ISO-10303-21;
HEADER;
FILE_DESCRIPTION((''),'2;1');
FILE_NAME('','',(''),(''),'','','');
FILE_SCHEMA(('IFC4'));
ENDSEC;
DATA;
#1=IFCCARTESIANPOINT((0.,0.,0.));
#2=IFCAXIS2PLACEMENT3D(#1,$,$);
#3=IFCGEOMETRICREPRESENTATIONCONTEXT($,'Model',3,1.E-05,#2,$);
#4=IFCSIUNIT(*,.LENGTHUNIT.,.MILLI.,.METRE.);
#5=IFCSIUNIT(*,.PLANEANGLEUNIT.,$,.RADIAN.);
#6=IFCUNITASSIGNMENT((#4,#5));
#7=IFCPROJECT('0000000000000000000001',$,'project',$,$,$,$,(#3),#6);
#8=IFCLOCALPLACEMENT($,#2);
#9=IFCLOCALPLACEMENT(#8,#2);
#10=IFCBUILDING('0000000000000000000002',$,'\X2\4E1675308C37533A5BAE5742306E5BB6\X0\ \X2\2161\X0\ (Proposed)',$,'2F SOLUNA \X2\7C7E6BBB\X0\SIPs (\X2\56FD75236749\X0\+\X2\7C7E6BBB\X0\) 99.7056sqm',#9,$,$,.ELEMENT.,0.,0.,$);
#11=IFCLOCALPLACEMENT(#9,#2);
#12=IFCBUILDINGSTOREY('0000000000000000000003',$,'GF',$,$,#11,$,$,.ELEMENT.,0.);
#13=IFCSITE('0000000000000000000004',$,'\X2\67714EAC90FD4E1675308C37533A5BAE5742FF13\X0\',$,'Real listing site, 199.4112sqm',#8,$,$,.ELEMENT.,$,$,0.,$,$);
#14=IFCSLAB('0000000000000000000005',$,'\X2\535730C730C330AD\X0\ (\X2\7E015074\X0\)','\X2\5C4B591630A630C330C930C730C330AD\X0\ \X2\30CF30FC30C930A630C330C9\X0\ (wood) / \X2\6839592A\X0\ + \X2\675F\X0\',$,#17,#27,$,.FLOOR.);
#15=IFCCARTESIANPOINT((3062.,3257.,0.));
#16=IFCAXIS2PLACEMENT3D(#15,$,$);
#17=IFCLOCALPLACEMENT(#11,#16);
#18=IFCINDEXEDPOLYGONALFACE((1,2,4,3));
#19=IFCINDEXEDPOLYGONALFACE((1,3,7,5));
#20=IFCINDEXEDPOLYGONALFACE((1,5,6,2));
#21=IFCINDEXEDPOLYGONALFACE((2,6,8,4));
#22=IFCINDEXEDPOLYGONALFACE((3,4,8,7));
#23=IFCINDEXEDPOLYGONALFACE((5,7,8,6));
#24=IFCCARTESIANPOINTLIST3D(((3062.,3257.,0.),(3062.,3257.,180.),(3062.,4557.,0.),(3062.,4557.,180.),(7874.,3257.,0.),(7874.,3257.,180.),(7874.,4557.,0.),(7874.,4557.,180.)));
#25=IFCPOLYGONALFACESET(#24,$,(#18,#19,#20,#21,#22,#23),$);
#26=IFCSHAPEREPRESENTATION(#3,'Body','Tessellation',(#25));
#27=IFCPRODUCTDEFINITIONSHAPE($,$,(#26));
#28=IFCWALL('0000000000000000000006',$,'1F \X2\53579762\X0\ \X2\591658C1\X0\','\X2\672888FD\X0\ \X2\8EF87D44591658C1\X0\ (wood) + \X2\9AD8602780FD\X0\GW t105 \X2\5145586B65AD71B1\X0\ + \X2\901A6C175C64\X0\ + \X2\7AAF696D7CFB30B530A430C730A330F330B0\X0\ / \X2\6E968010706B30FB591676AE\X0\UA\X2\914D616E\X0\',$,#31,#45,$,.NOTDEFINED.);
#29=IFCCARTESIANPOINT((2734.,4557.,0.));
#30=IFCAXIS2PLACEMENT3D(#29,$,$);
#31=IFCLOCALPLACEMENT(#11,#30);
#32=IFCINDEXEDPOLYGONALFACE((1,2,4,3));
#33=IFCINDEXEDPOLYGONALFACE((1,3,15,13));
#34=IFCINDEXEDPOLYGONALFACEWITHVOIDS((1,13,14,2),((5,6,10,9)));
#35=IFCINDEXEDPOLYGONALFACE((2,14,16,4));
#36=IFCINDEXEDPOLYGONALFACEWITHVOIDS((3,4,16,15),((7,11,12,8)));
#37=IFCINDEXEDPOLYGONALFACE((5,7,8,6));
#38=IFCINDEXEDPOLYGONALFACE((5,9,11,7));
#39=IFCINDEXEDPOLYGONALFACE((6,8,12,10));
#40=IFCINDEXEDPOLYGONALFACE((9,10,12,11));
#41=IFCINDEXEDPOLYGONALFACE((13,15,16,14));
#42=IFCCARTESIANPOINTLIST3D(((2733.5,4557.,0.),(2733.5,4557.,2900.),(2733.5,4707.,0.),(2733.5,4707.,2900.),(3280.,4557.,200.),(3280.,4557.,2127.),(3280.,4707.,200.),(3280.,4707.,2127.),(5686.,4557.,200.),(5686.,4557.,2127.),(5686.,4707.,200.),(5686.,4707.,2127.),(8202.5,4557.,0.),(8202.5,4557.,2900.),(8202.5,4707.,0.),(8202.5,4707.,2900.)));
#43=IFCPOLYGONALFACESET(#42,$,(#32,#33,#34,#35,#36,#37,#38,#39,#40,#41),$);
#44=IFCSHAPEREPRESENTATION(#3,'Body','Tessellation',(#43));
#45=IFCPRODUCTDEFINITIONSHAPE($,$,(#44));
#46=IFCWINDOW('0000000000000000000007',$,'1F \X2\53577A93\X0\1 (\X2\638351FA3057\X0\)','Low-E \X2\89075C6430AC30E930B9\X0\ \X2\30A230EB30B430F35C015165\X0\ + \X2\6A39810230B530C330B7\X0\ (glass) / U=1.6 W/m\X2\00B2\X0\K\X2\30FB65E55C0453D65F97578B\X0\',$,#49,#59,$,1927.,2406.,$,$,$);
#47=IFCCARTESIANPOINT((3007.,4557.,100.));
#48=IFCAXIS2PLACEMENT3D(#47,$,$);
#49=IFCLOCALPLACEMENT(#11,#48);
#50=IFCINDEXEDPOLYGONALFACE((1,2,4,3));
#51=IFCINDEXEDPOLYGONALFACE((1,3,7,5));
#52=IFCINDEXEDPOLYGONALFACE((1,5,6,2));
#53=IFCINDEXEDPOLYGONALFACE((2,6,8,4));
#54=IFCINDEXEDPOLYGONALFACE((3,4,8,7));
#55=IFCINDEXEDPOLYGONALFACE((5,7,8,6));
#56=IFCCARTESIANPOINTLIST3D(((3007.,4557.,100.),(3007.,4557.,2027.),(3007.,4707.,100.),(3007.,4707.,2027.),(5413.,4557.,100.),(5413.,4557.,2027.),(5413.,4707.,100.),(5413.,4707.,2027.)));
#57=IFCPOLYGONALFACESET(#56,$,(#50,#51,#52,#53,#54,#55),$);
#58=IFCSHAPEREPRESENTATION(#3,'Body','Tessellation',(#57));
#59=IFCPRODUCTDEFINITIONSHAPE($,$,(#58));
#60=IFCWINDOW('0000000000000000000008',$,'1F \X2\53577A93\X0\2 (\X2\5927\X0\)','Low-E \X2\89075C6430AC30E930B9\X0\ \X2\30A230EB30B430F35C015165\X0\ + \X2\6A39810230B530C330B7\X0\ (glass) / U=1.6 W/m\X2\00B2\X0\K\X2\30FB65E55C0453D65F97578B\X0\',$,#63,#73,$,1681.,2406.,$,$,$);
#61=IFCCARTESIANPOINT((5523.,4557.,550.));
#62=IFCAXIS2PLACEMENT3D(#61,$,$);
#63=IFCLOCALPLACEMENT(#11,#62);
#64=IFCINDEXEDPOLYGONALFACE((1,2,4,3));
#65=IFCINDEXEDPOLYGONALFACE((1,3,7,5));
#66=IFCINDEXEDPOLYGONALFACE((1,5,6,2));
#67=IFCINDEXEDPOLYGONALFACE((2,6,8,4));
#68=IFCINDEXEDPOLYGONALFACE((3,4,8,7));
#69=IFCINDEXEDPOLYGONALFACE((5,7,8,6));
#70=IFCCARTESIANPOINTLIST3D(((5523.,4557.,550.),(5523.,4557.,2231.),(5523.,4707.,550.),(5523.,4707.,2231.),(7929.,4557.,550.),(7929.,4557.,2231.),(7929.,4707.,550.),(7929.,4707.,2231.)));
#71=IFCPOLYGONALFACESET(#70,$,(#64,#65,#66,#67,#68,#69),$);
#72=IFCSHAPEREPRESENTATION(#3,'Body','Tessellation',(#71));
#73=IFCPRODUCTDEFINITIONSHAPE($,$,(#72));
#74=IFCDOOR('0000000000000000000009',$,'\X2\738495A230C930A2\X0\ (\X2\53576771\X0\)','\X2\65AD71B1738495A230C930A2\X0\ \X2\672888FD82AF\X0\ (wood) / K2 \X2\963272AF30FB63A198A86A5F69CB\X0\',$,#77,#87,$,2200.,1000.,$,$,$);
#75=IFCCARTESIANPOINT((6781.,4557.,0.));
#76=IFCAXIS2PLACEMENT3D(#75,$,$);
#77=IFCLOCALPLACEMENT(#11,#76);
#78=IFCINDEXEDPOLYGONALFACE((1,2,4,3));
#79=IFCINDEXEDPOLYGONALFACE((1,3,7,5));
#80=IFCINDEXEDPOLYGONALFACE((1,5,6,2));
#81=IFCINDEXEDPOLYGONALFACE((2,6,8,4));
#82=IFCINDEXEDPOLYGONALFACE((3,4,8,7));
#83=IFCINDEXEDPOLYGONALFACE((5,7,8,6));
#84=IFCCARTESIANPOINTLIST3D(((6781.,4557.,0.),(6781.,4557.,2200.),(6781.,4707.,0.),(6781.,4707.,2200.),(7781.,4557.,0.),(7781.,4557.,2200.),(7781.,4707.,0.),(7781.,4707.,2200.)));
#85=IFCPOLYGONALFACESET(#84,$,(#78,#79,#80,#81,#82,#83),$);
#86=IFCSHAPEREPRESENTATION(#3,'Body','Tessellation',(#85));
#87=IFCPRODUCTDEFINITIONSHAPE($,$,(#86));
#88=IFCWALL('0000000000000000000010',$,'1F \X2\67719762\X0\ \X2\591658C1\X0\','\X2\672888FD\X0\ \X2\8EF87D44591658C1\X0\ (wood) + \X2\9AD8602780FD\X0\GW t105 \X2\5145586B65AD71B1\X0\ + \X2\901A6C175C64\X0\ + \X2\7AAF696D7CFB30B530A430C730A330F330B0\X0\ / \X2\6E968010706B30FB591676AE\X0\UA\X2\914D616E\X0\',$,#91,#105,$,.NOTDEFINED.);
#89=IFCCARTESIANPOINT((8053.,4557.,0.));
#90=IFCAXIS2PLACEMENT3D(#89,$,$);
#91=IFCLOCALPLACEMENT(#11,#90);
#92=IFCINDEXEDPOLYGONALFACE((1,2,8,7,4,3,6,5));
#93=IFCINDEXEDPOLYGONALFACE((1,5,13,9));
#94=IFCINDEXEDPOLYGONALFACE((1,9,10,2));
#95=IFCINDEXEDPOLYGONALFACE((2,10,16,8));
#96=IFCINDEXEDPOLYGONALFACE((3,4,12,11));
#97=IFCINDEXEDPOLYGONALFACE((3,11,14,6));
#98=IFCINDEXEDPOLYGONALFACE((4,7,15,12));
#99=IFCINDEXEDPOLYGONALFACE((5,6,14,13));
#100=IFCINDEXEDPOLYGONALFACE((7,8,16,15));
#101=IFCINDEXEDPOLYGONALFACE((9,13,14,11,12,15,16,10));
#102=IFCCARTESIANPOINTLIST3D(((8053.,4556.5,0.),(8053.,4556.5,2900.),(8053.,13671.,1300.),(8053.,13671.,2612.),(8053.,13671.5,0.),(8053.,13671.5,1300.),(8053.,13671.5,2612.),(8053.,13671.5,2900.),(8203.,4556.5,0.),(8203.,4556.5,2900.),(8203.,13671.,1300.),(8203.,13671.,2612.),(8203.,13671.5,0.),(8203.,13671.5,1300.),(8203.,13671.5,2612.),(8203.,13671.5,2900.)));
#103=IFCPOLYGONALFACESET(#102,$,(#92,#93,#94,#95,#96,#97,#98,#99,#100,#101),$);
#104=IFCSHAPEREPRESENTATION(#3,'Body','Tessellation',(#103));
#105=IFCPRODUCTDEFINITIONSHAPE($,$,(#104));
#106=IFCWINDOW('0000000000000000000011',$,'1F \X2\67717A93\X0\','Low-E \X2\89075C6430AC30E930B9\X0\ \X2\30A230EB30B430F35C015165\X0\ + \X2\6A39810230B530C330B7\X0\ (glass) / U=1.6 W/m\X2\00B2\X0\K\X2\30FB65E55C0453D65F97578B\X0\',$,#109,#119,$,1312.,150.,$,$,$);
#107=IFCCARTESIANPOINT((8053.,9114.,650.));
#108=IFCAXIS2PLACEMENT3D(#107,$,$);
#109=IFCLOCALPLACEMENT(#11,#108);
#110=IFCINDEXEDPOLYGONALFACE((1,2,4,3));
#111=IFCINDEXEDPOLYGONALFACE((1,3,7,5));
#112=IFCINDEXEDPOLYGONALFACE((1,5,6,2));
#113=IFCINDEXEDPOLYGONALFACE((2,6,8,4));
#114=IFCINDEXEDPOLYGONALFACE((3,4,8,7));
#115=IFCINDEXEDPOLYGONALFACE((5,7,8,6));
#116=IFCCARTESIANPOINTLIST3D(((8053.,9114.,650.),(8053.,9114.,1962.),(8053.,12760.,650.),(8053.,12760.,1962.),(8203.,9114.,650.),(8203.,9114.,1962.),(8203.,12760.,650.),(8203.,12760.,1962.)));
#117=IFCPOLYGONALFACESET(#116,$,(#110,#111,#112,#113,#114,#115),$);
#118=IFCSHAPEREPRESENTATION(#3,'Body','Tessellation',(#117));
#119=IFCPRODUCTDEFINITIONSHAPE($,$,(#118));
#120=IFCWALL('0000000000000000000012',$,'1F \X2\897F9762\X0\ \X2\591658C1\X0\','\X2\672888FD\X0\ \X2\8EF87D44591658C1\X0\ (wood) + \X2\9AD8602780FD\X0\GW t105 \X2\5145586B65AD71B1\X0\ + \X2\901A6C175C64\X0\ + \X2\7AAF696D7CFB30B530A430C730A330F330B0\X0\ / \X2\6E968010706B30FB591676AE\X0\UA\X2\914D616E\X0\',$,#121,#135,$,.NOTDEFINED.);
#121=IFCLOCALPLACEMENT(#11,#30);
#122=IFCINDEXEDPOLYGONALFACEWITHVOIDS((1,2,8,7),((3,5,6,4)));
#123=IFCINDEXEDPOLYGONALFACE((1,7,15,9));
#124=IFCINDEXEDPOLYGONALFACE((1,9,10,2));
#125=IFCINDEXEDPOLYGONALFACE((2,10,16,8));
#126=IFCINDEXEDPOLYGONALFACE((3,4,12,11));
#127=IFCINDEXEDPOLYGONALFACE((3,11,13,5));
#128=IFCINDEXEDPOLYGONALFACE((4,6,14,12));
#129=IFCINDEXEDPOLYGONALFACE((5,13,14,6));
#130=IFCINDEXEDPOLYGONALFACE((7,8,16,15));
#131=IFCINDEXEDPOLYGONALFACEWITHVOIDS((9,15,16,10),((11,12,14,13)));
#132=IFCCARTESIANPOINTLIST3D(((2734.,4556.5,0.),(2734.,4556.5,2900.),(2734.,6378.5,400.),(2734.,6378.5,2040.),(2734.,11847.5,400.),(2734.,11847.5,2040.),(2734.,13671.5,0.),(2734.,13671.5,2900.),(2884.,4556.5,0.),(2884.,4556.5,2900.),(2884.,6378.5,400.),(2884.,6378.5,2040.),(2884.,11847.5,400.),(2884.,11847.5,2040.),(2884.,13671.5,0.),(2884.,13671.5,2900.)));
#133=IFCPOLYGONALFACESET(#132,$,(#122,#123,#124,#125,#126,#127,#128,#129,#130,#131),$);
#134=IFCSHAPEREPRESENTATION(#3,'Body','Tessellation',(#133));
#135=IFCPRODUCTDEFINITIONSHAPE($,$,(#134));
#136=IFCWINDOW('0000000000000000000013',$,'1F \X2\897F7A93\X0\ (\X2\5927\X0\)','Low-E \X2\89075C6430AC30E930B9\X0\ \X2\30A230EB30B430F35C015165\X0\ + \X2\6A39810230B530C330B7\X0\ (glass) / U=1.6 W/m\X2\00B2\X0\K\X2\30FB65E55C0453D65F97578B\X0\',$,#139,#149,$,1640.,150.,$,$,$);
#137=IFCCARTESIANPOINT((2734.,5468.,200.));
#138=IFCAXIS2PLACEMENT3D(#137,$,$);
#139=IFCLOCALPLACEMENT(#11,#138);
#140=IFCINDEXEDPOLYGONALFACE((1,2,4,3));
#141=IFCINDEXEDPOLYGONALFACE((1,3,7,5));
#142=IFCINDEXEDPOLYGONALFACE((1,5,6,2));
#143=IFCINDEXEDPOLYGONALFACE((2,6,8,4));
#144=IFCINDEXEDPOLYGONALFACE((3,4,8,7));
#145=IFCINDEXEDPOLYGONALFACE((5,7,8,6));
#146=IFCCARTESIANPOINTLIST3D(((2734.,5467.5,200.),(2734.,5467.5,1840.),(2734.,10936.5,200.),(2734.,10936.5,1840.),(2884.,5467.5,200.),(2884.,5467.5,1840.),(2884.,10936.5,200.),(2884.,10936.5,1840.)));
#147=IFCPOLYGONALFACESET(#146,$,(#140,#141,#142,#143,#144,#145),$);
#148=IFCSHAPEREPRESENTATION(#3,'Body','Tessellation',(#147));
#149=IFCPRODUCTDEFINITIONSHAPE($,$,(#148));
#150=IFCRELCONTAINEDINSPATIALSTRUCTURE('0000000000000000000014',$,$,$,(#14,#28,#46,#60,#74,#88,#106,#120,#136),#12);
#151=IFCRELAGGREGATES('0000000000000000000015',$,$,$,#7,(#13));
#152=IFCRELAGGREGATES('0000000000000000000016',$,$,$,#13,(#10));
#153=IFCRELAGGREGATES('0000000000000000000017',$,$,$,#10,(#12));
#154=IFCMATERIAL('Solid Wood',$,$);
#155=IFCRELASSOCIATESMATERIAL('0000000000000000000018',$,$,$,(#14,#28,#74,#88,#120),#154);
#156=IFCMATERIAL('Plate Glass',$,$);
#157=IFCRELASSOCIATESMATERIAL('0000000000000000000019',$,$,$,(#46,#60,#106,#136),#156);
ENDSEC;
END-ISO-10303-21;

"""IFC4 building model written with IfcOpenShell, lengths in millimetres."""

from ifc_helpers import new_model, si_unit, frame, frame_2d, origin, place, context, project, spatial, rectangle, extrude, material, element, fill, save


model = new_model("IFC4")

# Units and contexts
model_context = context("Model", 3, precision=1e-05, world=origin())
ifc_project = project(units=[si_unit("LENGTHUNIT", "METRE", prefix="MILLI"), si_unit("PLANEANGLEUNIT", "RADIAN")], contexts=[model_context])

# Site, building, storey
site_placement = place(None, origin())
site = spatial("IfcSite", under=ifc_project, at=site_placement, Name="東京都世田谷区宮坂３", ObjectType="Real listing site, 199.4112sqm", CompositionType="ELEMENT", RefElevation=0.0)
building_placement = place(site_placement, origin())
building = spatial("IfcBuilding", under=site, at=building_placement, Name="世田谷区宮坂の家 Ⅱ (Proposed)", ObjectType="2F SOLUNA 籾殻SIPs (国産杉+籾殻) 99.7056sqm", CompositionType="ELEMENT", ElevationOfRefHeight=0.0, ElevationOfTerrain=0.0)
storey_placement = place(building_placement, origin())
storey = spatial("IfcBuildingStorey", under=building, at=storey_placement, Name="GF", CompositionType="ELEMENT", Elevation=0.0)

# Slab
ifc_material_1 = material(Name="Solid Wood")
slab_1_placement = place(storey_placement, frame((3062.0, 3257.0, 0.0)))
element("IfcSlab", 1, at=slab_1_placement, inside=storey, material=ifc_material_1, Name="南デッキ (縁側)", Description="屋外ウッドデッキ ハードウッド (wood) / 根太 + 束", PredefinedType="FLOOR", context=model_context, shape_type="SweptSolid", body=[
    extrude(rectangle(XDim=4812.0, YDim=1300.0, at=frame_2d((2406.0, 650.0))), frame((3062.0, 3257.0, 0.0)), (0.0, 0.0, 1.0), 180.0),
])

# Wall, openings, windows, door
wall_1_placement = place(storey_placement, frame((2734.0, 4557.0, 0.0)))
wall_1 = element("IfcWall", 2, at=wall_1_placement, inside=storey, material=ifc_material_1, Name="1F 南面 外壁", Description="木製 軸組外壁 (wood) + 高性能GW t105 充填断熱 + 通気層 + 窯業系サイディング / 準耐火・外皮UA配慮", PredefinedType="NOTDEFINED", context=model_context, shape_type="SweptSolid", body=[
    extrude(rectangle(XDim=5469.0, YDim=150.0, at=frame_2d((2734.0, 75.0))), frame((2734.0, 4557.0, 0.0)), (0.0, 0.0, 1.0), 2900.0),
])
opening_1_placement = place(storey_placement, frame((3007.0, 4557.0, 100.0)))
opening_1 = element("IfcOpeningElement", 3, at=opening_1_placement, cuts=wall_1, PredefinedType="NOTDEFINED", context=model_context, shape_type="SweptSolid", body=[
    extrude(rectangle(XDim=2406.0, YDim=150.0, at=frame_2d((1203.0, 75.0))), frame((3007.0, 4557.0, 100.0)), (0.0, 0.0, 1.0), 1927.0),
])
opening_2_placement = place(storey_placement, frame((5523.0, 4557.0, 550.0)))
opening_2 = element("IfcOpeningElement", 4, at=opening_2_placement, cuts=wall_1, PredefinedType="NOTDEFINED", context=model_context, shape_type="SweptSolid", body=[
    extrude(rectangle(XDim=2406.0, YDim=150.0, at=frame_2d((1203.0, 75.0))), frame((5523.0, 4557.0, 550.0)), (0.0, 0.0, 1.0), 1681.0),
])
opening_3_placement = place(storey_placement, frame((6781.0, 4557.0, 0.0)))
opening_3 = element("IfcOpeningElement", 5, at=opening_3_placement, cuts=wall_1, PredefinedType="NOTDEFINED", context=model_context, shape_type="SweptSolid", body=[
    extrude(rectangle(XDim=1000.0, YDim=150.0, at=frame_2d((500.0, 75.0))), frame((6781.0, 4557.0, 0.0)), (0.0, 0.0, 1.0), 2200.0),
])
ifc_material_2 = material(Name="Plate Glass")
window_1_placement = place(storey_placement, frame((3007.0, 4557.0, 100.0)))
window_1 = element("IfcWindow", 6, at=window_1_placement, inside=storey, material=ifc_material_2, Name="1F 南窓1 (掃出し)", Description="Low-E 複層ガラス アルゴン封入 + 樹脂サッシ (glass) / U=1.6 W/m²K・日射取得型", OverallHeight=1927.0, OverallWidth=2406.0, context=model_context, shape_type="SweptSolid", body=[
    extrude(rectangle(XDim=2406.0, YDim=150.0, at=frame_2d((1203.0, 75.0))), frame((3007.0, 4557.0, 100.0)), (0.0, 0.0, 1.0), 1927.0),
])
fill(opening_1, window_1)
window_2_placement = place(storey_placement, frame((5523.0, 4557.0, 550.0)))
window_2 = element("IfcWindow", 7, at=window_2_placement, inside=storey, material=ifc_material_2, Name="1F 南窓2 (大)", Description="Low-E 複層ガラス アルゴン封入 + 樹脂サッシ (glass) / U=1.6 W/m²K・日射取得型", OverallHeight=1681.0, OverallWidth=2406.0, context=model_context, shape_type="SweptSolid", body=[
    extrude(rectangle(XDim=2406.0, YDim=150.0, at=frame_2d((1203.0, 75.0))), frame((5523.0, 4557.0, 550.0)), (0.0, 0.0, 1.0), 1681.0),
])
fill(opening_2, window_2)
door_placement = place(storey_placement, frame((6781.0, 4557.0, 0.0)))
door = element("IfcDoor", 8, at=door_placement, inside=storey, material=ifc_material_1, Name="玄関ドア (南東)", Description="断熱玄関ドア 木製芯 (wood) / K2 防犯・採風機構", OverallHeight=2200.0, OverallWidth=1000.0, context=model_context, shape_type="SweptSolid", body=[
    extrude(rectangle(XDim=1000.0, YDim=150.0, at=frame_2d((500.0, 75.0))), frame((6781.0, 4557.0, 0.0)), (0.0, 0.0, 1.0), 2200.0),
])
fill(opening_3, door)

# Walls, openings, windows
wall_2_placement = place(storey_placement, frame((8053.0, 4557.0, 0.0)))
wall_2 = element("IfcWall", 9, at=wall_2_placement, inside=storey, material=ifc_material_1, Name="1F 東面 外壁", Description="木製 軸組外壁 (wood) + 高性能GW t105 充填断熱 + 通気層 + 窯業系サイディング / 準耐火・外皮UA配慮", PredefinedType="NOTDEFINED", context=model_context, shape_type="SweptSolid", body=[
    extrude(rectangle(XDim=150.0, YDim=9115.0, at=frame_2d((75.0, 4557.0))), frame((8053.0, 4557.0, 0.0)), (0.0, 0.0, 1.0), 2900.0),
])
opening_4_placement = place(storey_placement, frame((8053.0, 9114.0, 650.0)))
opening_4 = element("IfcOpeningElement", 10, at=opening_4_placement, cuts=wall_2, PredefinedType="NOTDEFINED", context=model_context, shape_type="SweptSolid", body=[
    extrude(rectangle(XDim=150.0, YDim=3646.0, at=frame_2d((75.0, 1823.0))), frame((8053.0, 9114.0, 650.0)), (0.0, 0.0, 1.0), 1312.0),
])
window_3_placement = place(storey_placement, frame((8053.0, 9114.0, 650.0)))
window_3 = element("IfcWindow", 11, at=window_3_placement, inside=storey, material=ifc_material_2, Name="1F 東窓", Description="Low-E 複層ガラス アルゴン封入 + 樹脂サッシ (glass) / U=1.6 W/m²K・日射取得型", OverallHeight=1312.0, OverallWidth=150.0, context=model_context, shape_type="SweptSolid", body=[
    extrude(rectangle(XDim=150.0, YDim=3646.0, at=frame_2d((75.0, 1823.0))), frame((8053.0, 9114.0, 650.0)), (0.0, 0.0, 1.0), 1312.0),
])
fill(opening_4, window_3)
wall_3_placement = place(storey_placement, frame((2734.0, 4557.0, 0.0)))
wall_3 = element("IfcWall", 12, at=wall_3_placement, inside=storey, material=ifc_material_1, Name="1F 西面 外壁", Description="木製 軸組外壁 (wood) + 高性能GW t105 充填断熱 + 通気層 + 窯業系サイディング / 準耐火・外皮UA配慮", PredefinedType="NOTDEFINED", context=model_context, shape_type="SweptSolid", body=[
    extrude(rectangle(XDim=150.0, YDim=9115.0, at=frame_2d((75.0, 4557.0))), frame((2734.0, 4557.0, 0.0)), (0.0, 0.0, 1.0), 2900.0),
])
opening_5_placement = place(storey_placement, frame((2734.0, 5468.0, 200.0)))
opening_5 = element("IfcOpeningElement", 13, at=opening_5_placement, cuts=wall_3, PredefinedType="NOTDEFINED", context=model_context, shape_type="SweptSolid", body=[
    extrude(rectangle(XDim=150.0, YDim=5469.0, at=frame_2d((75.0, 2734.0))), frame((2734.0, 5468.0, 200.0)), (0.0, 0.0, 1.0), 1640.0),
])
window_4_placement = place(storey_placement, frame((2734.0, 5468.0, 200.0)))
window_4 = element("IfcWindow", 14, at=window_4_placement, inside=storey, material=ifc_material_2, Name="1F 西窓 (大)", Description="Low-E 複層ガラス アルゴン封入 + 樹脂サッシ (glass) / U=1.6 W/m²K・日射取得型", OverallHeight=1640.0, OverallWidth=150.0, context=model_context, shape_type="SweptSolid", body=[
    extrude(rectangle(XDim=150.0, YDim=5469.0, at=frame_2d((75.0, 2734.0))), frame((2734.0, 5468.0, 200.0)), (0.0, 0.0, 1.0), 1640.0),
])
fill(opening_5, window_4)

save(model, "model.ifc")
